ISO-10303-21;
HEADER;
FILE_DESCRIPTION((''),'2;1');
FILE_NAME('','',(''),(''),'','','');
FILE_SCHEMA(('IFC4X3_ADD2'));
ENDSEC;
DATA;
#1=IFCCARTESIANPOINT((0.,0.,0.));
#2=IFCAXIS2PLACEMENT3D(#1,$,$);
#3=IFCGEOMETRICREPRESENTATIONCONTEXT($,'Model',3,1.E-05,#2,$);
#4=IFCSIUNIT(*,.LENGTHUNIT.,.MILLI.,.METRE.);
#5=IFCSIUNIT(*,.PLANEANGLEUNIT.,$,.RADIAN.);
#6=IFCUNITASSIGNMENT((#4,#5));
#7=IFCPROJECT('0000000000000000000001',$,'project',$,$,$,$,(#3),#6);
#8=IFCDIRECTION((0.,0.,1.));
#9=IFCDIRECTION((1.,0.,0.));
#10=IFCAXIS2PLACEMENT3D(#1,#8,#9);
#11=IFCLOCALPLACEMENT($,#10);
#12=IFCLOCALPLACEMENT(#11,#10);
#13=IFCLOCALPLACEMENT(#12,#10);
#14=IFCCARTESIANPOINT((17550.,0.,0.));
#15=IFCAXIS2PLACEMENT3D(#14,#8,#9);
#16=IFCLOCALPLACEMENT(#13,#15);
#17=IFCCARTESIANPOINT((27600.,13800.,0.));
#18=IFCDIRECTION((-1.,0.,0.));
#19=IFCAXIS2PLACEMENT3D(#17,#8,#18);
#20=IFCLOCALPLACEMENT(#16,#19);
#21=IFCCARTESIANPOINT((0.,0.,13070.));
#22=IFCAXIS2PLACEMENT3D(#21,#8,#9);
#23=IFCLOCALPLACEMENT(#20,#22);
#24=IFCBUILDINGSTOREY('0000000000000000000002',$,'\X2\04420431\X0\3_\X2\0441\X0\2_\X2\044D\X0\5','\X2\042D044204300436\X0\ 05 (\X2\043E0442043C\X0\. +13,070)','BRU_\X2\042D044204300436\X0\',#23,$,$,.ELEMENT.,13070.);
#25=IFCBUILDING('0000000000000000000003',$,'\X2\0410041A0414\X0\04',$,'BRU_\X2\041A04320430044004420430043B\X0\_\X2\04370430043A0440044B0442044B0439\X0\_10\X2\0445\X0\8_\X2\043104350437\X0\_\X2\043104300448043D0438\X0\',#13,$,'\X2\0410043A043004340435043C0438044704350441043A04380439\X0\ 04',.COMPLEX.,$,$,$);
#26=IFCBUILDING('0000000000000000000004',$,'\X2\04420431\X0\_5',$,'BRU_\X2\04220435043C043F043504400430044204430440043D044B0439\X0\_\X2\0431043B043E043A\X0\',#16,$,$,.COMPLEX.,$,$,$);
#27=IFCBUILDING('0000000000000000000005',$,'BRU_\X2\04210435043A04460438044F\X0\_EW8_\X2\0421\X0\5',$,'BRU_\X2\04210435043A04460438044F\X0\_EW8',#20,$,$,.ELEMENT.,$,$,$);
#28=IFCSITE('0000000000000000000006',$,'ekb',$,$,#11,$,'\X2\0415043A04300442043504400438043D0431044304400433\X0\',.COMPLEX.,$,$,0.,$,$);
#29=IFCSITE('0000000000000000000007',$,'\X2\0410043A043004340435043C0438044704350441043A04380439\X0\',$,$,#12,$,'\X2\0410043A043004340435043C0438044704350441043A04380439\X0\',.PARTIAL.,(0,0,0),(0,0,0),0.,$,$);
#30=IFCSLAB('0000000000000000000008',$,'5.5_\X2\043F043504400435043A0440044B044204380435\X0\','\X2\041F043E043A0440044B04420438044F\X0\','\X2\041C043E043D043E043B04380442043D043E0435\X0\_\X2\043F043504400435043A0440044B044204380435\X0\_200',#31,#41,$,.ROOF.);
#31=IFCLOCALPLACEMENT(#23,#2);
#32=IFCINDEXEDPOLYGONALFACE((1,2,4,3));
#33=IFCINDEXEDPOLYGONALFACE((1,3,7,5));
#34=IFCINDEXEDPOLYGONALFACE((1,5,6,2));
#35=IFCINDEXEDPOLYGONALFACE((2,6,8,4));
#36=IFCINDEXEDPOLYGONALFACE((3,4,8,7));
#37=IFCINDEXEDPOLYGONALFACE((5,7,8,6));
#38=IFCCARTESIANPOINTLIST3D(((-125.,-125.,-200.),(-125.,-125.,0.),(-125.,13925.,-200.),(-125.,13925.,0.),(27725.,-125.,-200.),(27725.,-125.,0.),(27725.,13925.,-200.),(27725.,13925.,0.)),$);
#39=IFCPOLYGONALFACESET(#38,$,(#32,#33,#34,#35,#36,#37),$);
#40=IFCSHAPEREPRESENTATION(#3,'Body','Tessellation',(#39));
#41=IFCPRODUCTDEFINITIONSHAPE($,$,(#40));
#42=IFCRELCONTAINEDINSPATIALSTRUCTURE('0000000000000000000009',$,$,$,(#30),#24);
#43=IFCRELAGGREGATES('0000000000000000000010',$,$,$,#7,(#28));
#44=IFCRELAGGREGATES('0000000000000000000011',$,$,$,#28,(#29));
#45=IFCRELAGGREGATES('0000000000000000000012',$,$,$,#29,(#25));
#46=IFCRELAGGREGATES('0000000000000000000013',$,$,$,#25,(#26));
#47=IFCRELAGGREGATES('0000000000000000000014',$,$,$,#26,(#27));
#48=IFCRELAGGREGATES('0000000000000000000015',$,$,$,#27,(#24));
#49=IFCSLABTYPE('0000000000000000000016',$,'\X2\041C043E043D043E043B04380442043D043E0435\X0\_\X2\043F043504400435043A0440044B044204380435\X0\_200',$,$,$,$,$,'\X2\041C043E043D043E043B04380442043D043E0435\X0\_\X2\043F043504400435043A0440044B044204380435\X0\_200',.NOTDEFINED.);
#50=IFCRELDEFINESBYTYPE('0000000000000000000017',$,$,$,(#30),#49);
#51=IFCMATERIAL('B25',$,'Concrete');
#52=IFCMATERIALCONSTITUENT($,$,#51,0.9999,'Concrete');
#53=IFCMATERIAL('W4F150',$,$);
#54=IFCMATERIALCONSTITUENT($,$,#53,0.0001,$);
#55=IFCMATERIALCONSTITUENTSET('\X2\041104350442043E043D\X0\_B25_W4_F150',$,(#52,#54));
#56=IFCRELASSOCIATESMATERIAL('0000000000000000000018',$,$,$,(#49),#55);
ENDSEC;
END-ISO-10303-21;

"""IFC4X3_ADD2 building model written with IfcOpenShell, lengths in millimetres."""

from ifc_helpers import new_model, si_unit, frame, origin, origin_with_axes, place, context, project, spatial, polyline, outline, extrude, material, constituent, constituent_set, type_object, element, save


model = new_model("IFC4X3_ADD2")

# Units and contexts
model_context = context("Model", 3, precision=1e-05, world=origin())
ifc_project = project(units=[si_unit("LENGTHUNIT", "METRE", prefix="MILLI"), si_unit("PLANEANGLEUNIT", "RADIAN")], contexts=[model_context])

# Sites, buildings, storey
site_1_placement = place(None, origin_with_axes())
site_1 = spatial("IfcSite", under=ifc_project, at=site_1_placement, Name="ekb", LongName="Екатеринбург", CompositionType="COMPLEX", RefElevation=0.0)
site_2_placement = place(site_1_placement, origin_with_axes())
site_2 = spatial("IfcSite", under=site_1, at=site_2_placement, Name="Академический", LongName="Академический", CompositionType="PARTIAL", RefLatitude=(0, 0, 0), RefLongitude=(0, 0, 0), RefElevation=0.0)
building_1_placement = place(site_2_placement, origin_with_axes())
building_1 = spatial("IfcBuilding", under=site_2, at=building_1_placement, Name="АКД04", ObjectType="BRU_Квартал_закрытый_10х8_без_башни", LongName="Академический 04", CompositionType="COMPLEX")
building_2_placement = place(building_1_placement, frame((17550.0, 0.0, 0.0), z_axis=(0.0, 0.0, 1.0), x_axis=(1.0, 0.0, 0.0)))
building_2 = spatial("IfcBuilding", under=building_1, at=building_2_placement, Name="тб_5", ObjectType="BRU_Температурный_блок", CompositionType="COMPLEX")
building_3_placement = place(building_2_placement, frame((27600.0, 13800.0, 0.0), z_axis=(0.0, 0.0, 1.0), x_axis=(-1.0, 0.0, 0.0)))
building_3 = spatial("IfcBuilding", under=building_2, at=building_3_placement, Name="BRU_Секция_EW8_С5", ObjectType="BRU_Секция_EW8", CompositionType="ELEMENT")
storey_placement = place(building_3_placement, frame((0.0, 0.0, 13070.0), z_axis=(0.0, 0.0, 1.0), x_axis=(1.0, 0.0, 0.0)))
storey = spatial("IfcBuildingStorey", under=building_3, at=storey_placement, Name="тб3_с2_э5", Description="Этаж 05 (отм. +13,070)", ObjectType="BRU_Этаж", CompositionType="ELEMENT", Elevation=13070.0)

# Shared definitions
ifc_material_1 = material(Name="B25", Category="Concrete")
ifc_material_2 = material(Name="W4F150")

# Slab
ifc_constituent_1 = constituent(ifc_material_1, Category="Concrete", fraction=0.9999)
ifc_constituent_2 = constituent(ifc_material_2, fraction=0.0001)
ifc_constituent_set_1 = constituent_set(constituents=[ifc_constituent_1, ifc_constituent_2], Name="Бетон_B25_W4_F150")
slab_type = type_object("IfcSlabType", Name="Монолитное_перекрытие_200", ElementType="Монолитное_перекрытие_200", PredefinedType="NOTDEFINED", material=ifc_constituent_set_1)
slab_placement = place(storey_placement, frame((0.0, 0.0, -200.0), z_axis=(0.0, 0.0, 1.0), x_axis=(1.0, 0.0, 0.0)))
element("IfcSlab", 1, at=slab_placement, inside=storey, type_object=slab_type, Name="5.5_перекрытие", Description="Покрытия", ObjectType="Монолитное_перекрытие_200", PredefinedType="ROOF", context=model_context, shape_type="SweptSolid", body=[
    extrude(outline(polyline([(27725.0, 13925.0), (-125.0, 13925.0), (-125.0, -125.0), (27725.0, -125.0), (27725.0, 13925.0)])), origin_with_axes(), (0.0, 0.0, 1.0), 200.0),
])

save(model, "model.ifc")
